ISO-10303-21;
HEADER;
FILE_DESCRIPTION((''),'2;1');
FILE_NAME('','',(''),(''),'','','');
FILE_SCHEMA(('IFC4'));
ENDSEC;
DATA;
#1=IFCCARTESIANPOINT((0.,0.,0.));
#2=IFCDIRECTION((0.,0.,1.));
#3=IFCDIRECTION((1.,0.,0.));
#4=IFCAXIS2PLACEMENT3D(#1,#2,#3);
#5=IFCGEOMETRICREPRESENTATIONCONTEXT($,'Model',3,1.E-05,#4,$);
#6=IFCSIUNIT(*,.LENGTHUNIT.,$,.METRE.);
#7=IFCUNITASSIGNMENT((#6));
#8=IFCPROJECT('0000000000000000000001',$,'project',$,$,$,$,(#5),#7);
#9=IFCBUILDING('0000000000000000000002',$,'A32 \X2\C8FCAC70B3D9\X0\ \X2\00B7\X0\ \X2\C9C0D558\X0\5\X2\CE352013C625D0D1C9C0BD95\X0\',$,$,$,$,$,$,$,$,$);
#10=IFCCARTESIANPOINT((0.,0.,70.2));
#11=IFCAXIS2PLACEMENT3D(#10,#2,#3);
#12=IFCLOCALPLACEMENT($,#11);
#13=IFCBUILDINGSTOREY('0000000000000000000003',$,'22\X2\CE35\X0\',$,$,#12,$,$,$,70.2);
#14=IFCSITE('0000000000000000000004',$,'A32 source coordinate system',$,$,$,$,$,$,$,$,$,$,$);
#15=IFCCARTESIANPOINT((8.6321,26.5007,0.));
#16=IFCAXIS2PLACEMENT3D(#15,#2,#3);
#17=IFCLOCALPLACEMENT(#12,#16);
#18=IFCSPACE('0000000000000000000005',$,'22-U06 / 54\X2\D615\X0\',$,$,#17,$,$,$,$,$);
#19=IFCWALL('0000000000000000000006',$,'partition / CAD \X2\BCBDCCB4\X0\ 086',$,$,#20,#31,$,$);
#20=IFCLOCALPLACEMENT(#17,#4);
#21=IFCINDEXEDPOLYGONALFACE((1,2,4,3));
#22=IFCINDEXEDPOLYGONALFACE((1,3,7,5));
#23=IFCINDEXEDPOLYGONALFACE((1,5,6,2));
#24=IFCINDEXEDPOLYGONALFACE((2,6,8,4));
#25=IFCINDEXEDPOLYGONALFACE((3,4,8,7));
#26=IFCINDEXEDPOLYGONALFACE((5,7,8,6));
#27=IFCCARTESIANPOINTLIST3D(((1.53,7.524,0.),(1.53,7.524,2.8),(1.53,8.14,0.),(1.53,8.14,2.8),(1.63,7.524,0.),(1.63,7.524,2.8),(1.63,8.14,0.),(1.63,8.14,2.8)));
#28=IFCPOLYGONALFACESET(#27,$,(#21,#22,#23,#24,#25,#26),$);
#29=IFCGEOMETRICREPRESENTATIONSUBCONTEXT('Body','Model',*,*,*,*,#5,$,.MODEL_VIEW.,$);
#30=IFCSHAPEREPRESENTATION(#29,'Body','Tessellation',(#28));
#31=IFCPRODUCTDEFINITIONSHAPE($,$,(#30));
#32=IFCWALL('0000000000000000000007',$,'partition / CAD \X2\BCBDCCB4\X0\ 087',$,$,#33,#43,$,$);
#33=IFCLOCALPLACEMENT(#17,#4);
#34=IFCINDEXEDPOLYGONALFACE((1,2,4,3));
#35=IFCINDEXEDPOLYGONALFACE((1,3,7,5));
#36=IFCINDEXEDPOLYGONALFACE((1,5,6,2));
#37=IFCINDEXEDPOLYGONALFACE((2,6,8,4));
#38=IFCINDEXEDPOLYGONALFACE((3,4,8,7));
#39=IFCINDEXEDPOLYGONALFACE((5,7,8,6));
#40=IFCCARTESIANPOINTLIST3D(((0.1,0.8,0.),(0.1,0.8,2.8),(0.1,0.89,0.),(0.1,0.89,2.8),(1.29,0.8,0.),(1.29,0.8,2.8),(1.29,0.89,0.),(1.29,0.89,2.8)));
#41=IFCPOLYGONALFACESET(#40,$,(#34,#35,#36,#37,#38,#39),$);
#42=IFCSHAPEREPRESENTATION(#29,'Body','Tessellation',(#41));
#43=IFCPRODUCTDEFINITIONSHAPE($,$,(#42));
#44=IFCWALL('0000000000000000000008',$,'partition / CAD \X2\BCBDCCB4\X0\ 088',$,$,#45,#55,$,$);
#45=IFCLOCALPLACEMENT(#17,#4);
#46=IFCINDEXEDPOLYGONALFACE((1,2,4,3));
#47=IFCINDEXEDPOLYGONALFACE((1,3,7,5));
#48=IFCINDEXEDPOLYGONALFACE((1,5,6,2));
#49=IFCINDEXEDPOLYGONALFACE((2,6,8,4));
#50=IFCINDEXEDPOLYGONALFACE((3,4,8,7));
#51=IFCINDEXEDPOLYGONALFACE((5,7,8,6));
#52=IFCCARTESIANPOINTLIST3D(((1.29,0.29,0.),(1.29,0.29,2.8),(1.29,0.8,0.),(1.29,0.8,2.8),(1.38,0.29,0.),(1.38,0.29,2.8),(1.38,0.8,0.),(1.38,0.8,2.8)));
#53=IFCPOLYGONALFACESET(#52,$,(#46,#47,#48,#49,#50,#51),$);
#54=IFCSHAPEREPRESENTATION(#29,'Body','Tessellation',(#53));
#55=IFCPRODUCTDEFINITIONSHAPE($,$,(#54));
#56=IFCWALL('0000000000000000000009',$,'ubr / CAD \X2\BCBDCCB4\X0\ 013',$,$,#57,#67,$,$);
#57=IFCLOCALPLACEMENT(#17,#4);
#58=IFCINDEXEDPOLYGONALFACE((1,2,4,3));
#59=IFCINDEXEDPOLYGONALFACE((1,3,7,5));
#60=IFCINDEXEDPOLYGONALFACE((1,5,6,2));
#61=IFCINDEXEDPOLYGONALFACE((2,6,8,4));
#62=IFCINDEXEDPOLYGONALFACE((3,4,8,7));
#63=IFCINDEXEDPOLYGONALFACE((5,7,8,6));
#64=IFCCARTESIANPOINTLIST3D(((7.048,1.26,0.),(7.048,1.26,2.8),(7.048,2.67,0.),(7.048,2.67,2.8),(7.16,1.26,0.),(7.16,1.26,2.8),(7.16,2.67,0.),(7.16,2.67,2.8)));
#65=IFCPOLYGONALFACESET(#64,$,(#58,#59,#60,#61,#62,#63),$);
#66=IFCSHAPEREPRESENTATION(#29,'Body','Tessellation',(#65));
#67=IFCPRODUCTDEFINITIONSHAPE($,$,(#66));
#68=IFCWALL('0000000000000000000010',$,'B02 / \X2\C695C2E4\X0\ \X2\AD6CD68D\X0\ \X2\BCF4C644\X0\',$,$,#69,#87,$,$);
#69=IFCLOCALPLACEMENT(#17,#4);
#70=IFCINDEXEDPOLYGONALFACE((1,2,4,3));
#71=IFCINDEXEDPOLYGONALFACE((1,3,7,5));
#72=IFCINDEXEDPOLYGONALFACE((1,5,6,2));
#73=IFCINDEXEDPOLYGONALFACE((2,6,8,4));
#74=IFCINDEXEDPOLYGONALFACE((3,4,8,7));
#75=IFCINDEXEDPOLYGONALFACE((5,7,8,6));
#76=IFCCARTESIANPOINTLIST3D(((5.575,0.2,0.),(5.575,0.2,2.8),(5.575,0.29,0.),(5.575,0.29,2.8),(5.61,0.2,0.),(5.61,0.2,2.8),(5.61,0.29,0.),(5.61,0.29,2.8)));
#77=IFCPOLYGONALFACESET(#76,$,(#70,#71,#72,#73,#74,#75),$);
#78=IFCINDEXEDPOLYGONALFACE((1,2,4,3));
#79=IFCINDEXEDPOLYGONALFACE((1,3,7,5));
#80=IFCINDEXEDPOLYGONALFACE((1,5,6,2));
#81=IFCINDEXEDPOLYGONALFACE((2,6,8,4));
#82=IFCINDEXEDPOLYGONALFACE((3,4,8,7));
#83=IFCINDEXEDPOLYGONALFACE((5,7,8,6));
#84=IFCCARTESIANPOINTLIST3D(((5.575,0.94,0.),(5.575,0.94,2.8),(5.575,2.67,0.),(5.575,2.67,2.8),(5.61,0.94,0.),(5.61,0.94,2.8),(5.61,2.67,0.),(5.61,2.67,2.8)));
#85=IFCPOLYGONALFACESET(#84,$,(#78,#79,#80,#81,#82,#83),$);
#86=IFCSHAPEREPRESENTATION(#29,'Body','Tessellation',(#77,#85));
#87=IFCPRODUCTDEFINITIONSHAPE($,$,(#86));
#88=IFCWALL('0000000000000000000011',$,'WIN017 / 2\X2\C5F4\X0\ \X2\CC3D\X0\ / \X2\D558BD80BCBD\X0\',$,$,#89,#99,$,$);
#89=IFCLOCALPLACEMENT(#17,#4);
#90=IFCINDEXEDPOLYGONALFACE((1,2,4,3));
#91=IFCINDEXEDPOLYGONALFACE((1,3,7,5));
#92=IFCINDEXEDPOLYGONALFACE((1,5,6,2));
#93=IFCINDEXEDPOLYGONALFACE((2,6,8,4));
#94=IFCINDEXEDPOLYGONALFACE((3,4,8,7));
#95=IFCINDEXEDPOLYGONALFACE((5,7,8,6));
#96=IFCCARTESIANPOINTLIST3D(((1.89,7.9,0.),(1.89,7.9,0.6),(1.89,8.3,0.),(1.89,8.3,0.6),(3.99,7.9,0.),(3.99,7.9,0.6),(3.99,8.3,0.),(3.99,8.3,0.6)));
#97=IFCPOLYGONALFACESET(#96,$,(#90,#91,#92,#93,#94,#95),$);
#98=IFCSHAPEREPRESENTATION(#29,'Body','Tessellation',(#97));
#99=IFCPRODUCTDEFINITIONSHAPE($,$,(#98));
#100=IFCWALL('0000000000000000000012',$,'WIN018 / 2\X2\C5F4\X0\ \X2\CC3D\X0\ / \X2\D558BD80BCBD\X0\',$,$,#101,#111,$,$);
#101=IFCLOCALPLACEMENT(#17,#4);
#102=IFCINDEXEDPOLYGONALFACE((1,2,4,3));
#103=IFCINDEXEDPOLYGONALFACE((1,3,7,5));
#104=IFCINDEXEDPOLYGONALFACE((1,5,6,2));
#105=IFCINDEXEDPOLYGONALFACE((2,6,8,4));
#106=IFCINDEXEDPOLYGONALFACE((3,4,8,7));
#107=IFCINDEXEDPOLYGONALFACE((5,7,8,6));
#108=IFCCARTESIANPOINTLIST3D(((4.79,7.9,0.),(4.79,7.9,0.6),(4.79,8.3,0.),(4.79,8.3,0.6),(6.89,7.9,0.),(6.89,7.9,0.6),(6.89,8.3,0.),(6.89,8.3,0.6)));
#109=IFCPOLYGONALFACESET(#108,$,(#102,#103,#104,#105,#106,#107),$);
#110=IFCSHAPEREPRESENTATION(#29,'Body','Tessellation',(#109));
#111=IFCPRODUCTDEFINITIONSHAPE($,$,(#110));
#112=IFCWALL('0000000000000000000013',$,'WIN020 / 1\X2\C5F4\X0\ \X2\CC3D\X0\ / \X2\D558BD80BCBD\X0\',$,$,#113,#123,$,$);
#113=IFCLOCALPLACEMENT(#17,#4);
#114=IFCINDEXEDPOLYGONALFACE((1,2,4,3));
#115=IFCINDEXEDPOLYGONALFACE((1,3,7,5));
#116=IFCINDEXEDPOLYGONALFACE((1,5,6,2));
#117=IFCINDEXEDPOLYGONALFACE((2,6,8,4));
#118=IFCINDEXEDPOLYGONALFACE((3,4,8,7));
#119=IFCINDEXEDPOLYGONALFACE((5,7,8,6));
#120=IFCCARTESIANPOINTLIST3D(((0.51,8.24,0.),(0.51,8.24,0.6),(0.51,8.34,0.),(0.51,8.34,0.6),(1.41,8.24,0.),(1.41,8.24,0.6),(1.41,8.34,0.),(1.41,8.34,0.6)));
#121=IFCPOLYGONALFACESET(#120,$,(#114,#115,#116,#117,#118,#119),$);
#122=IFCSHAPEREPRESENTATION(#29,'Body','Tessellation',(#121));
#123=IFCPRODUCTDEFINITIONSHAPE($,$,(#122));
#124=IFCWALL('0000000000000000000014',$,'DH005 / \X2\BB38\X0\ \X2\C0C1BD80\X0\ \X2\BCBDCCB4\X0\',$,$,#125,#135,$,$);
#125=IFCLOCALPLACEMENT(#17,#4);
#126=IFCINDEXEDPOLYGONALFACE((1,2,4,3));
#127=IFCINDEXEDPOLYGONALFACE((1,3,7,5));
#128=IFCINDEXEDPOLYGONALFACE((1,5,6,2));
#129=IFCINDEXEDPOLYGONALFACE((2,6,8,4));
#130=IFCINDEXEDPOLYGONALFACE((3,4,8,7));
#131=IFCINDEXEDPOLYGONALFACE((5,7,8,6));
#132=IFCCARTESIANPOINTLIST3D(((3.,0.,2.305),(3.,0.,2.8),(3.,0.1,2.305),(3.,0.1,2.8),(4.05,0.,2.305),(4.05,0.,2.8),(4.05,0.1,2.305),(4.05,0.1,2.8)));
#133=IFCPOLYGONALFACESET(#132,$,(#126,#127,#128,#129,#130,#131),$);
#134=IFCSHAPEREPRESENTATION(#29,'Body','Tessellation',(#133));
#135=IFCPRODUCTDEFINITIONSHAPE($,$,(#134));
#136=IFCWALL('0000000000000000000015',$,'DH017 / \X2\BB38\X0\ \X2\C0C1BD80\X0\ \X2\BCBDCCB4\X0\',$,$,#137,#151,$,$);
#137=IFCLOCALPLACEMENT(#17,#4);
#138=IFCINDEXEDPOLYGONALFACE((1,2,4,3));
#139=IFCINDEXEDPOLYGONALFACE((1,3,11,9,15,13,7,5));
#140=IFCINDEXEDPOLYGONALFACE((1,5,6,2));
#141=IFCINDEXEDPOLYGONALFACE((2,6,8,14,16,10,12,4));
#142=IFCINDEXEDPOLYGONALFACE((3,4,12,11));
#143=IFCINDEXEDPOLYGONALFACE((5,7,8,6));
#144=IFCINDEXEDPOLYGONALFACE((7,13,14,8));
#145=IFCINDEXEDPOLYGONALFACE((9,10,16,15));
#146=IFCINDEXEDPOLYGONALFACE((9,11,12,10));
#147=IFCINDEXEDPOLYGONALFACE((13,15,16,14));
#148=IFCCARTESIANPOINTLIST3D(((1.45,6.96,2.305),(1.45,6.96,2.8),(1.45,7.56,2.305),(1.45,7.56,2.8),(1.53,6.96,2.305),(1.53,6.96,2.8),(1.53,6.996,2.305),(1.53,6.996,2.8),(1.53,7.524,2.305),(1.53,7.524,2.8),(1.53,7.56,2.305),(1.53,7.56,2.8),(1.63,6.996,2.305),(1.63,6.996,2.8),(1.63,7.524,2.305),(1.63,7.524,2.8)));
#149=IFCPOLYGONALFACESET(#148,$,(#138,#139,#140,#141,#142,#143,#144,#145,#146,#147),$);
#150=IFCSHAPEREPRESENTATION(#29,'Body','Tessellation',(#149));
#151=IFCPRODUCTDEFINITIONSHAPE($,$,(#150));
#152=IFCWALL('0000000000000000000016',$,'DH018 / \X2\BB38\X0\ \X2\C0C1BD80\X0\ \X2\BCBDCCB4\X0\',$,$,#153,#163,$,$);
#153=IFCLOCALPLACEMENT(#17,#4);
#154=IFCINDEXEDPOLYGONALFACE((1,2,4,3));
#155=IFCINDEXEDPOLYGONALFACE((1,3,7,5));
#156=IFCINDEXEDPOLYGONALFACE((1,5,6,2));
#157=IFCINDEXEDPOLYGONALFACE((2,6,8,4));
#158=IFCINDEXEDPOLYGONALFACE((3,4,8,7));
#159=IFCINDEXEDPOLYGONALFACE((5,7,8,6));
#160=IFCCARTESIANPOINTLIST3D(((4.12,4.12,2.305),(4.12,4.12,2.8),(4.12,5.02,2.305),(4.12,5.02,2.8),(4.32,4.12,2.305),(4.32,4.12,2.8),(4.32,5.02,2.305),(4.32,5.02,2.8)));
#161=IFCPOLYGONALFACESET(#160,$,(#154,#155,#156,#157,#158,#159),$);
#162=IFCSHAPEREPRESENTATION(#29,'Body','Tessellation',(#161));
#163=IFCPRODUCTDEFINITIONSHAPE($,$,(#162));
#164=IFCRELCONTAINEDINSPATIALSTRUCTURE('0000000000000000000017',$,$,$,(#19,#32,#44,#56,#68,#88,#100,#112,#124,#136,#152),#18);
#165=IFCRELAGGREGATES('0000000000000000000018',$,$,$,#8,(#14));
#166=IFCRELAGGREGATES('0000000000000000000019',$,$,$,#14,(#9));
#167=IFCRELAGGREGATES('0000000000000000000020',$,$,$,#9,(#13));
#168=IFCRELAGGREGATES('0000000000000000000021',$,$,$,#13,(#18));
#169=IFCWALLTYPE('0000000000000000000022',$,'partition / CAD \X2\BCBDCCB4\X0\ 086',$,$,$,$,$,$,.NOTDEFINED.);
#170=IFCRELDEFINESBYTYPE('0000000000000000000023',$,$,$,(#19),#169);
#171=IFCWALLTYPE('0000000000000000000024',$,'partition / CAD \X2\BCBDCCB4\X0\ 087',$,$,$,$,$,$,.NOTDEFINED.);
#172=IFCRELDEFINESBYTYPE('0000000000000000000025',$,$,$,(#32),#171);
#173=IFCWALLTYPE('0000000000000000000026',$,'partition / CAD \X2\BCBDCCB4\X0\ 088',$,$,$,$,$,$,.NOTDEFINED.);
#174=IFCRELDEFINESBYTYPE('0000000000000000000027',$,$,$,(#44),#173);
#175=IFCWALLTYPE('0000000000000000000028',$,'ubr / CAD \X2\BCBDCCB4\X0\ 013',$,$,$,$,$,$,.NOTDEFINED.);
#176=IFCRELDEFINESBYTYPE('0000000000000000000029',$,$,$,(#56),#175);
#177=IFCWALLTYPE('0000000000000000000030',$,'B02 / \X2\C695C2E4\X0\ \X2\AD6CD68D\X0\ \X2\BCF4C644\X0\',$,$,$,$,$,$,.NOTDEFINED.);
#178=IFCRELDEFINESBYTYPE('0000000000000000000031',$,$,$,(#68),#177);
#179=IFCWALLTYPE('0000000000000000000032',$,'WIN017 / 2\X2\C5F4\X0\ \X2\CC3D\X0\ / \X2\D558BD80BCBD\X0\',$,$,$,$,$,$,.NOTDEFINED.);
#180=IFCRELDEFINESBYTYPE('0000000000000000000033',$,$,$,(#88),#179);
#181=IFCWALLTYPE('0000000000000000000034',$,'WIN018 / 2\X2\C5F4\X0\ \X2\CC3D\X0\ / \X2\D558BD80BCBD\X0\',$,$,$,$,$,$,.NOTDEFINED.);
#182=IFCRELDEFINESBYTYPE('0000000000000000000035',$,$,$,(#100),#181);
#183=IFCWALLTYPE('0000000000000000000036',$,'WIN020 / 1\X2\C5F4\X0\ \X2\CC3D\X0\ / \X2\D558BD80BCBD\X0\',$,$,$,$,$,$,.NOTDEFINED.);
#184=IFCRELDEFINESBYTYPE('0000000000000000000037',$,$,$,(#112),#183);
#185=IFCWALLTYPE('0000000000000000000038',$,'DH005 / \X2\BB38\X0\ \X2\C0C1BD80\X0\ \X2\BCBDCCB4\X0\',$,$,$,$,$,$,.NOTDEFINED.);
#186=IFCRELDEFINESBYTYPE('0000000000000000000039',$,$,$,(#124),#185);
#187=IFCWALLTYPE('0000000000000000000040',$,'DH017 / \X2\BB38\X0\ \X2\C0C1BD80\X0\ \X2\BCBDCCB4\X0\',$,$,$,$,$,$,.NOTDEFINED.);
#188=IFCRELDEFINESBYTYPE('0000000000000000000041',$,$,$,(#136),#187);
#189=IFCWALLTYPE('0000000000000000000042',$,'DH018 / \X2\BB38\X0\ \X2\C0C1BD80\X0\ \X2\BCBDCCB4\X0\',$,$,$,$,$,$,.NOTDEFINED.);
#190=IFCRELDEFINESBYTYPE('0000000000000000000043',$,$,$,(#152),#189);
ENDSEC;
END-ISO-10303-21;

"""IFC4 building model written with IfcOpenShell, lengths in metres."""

from ifc_helpers import new_model, si_unit, frame, origin, origin_with_axes, place, context, subcontext, project, spatial, polyline, outline, extrude, source, transform, mapped, type_object, type_shapes, element, save


model = new_model("IFC4")

# Units and contexts
model_context = context("Model", 3, precision=1e-05, world=origin_with_axes())
body_context = subcontext(model_context, "Body", "Model", "MODEL_VIEW")
ifc_project = project(units=[si_unit("LENGTHUNIT", "METRE")], contexts=[model_context])

# Site, building, storey, space
site = spatial("IfcSite", under=ifc_project, Name="A32 source coordinate system")
building = spatial("IfcBuilding", under=site, Name="A32 주거동 · 지하5층–옥탑지붕")
storey_placement = place(None, frame((0.0, 0.0, 70.2), z_axis=(0.0, 0.0, 1.0), x_axis=(1.0, 0.0, 0.0)))
storey = spatial("IfcBuildingStorey", under=building, at=storey_placement, Name="22층", Elevation=70.2)
space_placement = place(storey_placement, frame((8.6321, 26.5007, 0.0), z_axis=(0.0, 0.0, 1.0), x_axis=(1.0, 0.0, 0.0)))
space = spatial("IfcSpace", under=storey, at=space_placement, Name="22-U06 / 54형")

# Walls
wall_type_1 = type_object("IfcWallType", Name="partition / CAD 벽체 086", PredefinedType="NOTDEFINED")
shared_shape_1 = source(origin(), body_context, "Body", "SweptSolid", [
    extrude(outline(polyline([(1.53, 7.524), (1.53, 8.14), (1.63, 8.14), (1.63, 7.524), (1.53, 7.524)])), origin(), (0.0, 0.0, 1.0), 2.8),
])
type_shapes(wall_type_1, [shared_shape_1])
wall_1_placement = place(space_placement, origin_with_axes())
element("IfcWall", 1, at=wall_1_placement, inside=space, type_object=wall_type_1, Name="partition / CAD 벽체 086", context=body_context, shape_type="MappedRepresentation", body=[
    mapped(shared_shape_1, transform((0.0, 0.0, 0.0), scale=1.0)),
])
wall_type_2 = type_object("IfcWallType", Name="partition / CAD 벽체 087", PredefinedType="NOTDEFINED")
shared_shape_2 = source(origin(), body_context, "Body", "SweptSolid", [
    extrude(outline(polyline([(1.29, 0.8), (0.1, 0.8), (0.1, 0.89), (1.29, 0.89), (1.29, 0.8)])), origin(), (0.0, 0.0, 1.0), 2.8),
])
type_shapes(wall_type_2, [shared_shape_2])
wall_2_placement = place(space_placement, origin_with_axes())
element("IfcWall", 2, at=wall_2_placement, inside=space, type_object=wall_type_2, Name="partition / CAD 벽체 087", context=body_context, shape_type="MappedRepresentation", body=[
    mapped(shared_shape_2, transform((0.0, 0.0, 0.0), scale=1.0)),
])
wall_type_3 = type_object("IfcWallType", Name="partition / CAD 벽체 088", PredefinedType="NOTDEFINED")
shared_shape_3 = source(origin(), body_context, "Body", "SweptSolid", [
    extrude(outline(polyline([(1.29, 0.29), (1.29, 0.8), (1.38, 0.8), (1.38, 0.29), (1.29, 0.29)])), origin(), (0.0, 0.0, 1.0), 2.8),
])
type_shapes(wall_type_3, [shared_shape_3])
wall_3_placement = place(space_placement, origin_with_axes())
element("IfcWall", 3, at=wall_3_placement, inside=space, type_object=wall_type_3, Name="partition / CAD 벽체 088", context=body_context, shape_type="MappedRepresentation", body=[
    mapped(shared_shape_3, transform((0.0, 0.0, 0.0), scale=1.0)),
])
wall_type_4 = type_object("IfcWallType", Name="ubr / CAD 벽체 013", PredefinedType="NOTDEFINED")
shared_shape_4 = source(origin(), body_context, "Body", "SweptSolid", [
    extrude(outline(polyline([(7.16, 1.26), (7.048, 1.26), (7.048, 2.67), (7.16, 2.67), (7.16, 1.26)])), origin(), (0.0, 0.0, 1.0), 2.8),
])
type_shapes(wall_type_4, [shared_shape_4])
wall_4_placement = place(space_placement, origin_with_axes())
element("IfcWall", 4, at=wall_4_placement, inside=space, type_object=wall_type_4, Name="ubr / CAD 벽체 013", context=body_context, shape_type="MappedRepresentation", body=[
    mapped(shared_shape_4, transform((0.0, 0.0, 0.0), scale=1.0)),
])
wall_type_5 = type_object("IfcWallType", Name="B02 / 욕실 구획 보완", PredefinedType="NOTDEFINED")
shared_shape_5 = source(origin(), body_context, "Body", "SweptSolid", [
    extrude(outline(polyline([(5.575, 0.2), (5.575, 0.29), (5.61, 0.29), (5.61, 0.2), (5.575, 0.2)])), origin(), (0.0, 0.0, 1.0), 2.8),
    extrude(outline(polyline([(5.575, 0.94), (5.575, 2.67), (5.61, 2.67), (5.61, 0.94), (5.575, 0.94)])), origin(), (0.0, 0.0, 1.0), 2.8),
])
type_shapes(wall_type_5, [shared_shape_5])
wall_5_placement = place(space_placement, origin_with_axes())
element("IfcWall", 5, at=wall_5_placement, inside=space, type_object=wall_type_5, Name="B02 / 욕실 구획 보완", context=body_context, shape_type="MappedRepresentation", body=[
    mapped(shared_shape_5, transform((0.0, 0.0, 0.0), scale=1.0)),
])
wall_type_6 = type_object("IfcWallType", Name="WIN017 / 2열 창 / 하부벽", PredefinedType="NOTDEFINED")
shared_shape_6 = source(origin(), body_context, "Body", "SweptSolid", [
    extrude(outline(polyline([(3.99, 8.3), (3.99, 7.9), (1.89, 7.9), (1.89, 8.3), (3.99, 8.3)])), origin(), (0.0, 0.0, 1.0), 0.6),
])
type_shapes(wall_type_6, [shared_shape_6])
wall_6_placement = place(space_placement, origin_with_axes())
element("IfcWall", 6, at=wall_6_placement, inside=space, type_object=wall_type_6, Name="WIN017 / 2열 창 / 하부벽", context=body_context, shape_type="MappedRepresentation", body=[
    mapped(shared_shape_6, transform((0.0, 0.0, 0.0), scale=1.0)),
])
wall_type_7 = type_object("IfcWallType", Name="WIN018 / 2열 창 / 하부벽", PredefinedType="NOTDEFINED")
shared_shape_7 = source(origin(), body_context, "Body", "SweptSolid", [
    extrude(outline(polyline([(6.89, 8.3), (6.89, 7.9), (4.79, 7.9), (4.79, 8.3), (6.89, 8.3)])), origin(), (0.0, 0.0, 1.0), 0.6),
])
type_shapes(wall_type_7, [shared_shape_7])
wall_7_placement = place(space_placement, origin_with_axes())
element("IfcWall", 7, at=wall_7_placement, inside=space, type_object=wall_type_7, Name="WIN018 / 2열 창 / 하부벽", context=body_context, shape_type="MappedRepresentation", body=[
    mapped(shared_shape_7, transform((0.0, 0.0, 0.0), scale=1.0)),
])
wall_type_8 = type_object("IfcWallType", Name="WIN020 / 1열 창 / 하부벽", PredefinedType="NOTDEFINED")
shared_shape_8 = source(origin(), body_context, "Body", "SweptSolid", [
    extrude(outline(polyline([(1.41, 8.34), (1.41, 8.24), (0.51, 8.24), (0.51, 8.34), (1.41, 8.34)])), origin(), (0.0, 0.0, 1.0), 0.6),
])
type_shapes(wall_type_8, [shared_shape_8])
wall_8_placement = place(space_placement, origin_with_axes())
element("IfcWall", 8, at=wall_8_placement, inside=space, type_object=wall_type_8, Name="WIN020 / 1열 창 / 하부벽", context=body_context, shape_type="MappedRepresentation", body=[
    mapped(shared_shape_8, transform((0.0, 0.0, 0.0), scale=1.0)),
])
wall_type_9 = type_object("IfcWallType", Name="DH005 / 문 상부 벽체", PredefinedType="NOTDEFINED")
shared_shape_9 = source(origin(), body_context, "Body", "SweptSolid", [
    extrude(outline(polyline([(4.05, 0.0), (3.0, 0.0), (3.0, 0.1), (4.05, 0.1), (4.05, 0.0)])), frame((0.0, 0.0, 2.305)), (0.0, 0.0, 1.0), 0.495),
])
type_shapes(wall_type_9, [shared_shape_9])
wall_9_placement = place(space_placement, origin_with_axes())
element("IfcWall", 9, at=wall_9_placement, inside=space, type_object=wall_type_9, Name="DH005 / 문 상부 벽체", context=body_context, shape_type="MappedRepresentation", body=[
    mapped(shared_shape_9, transform((0.0, 0.0, 0.0), scale=1.0)),
])
wall_type_10 = type_object("IfcWallType", Name="DH017 / 문 상부 벽체", PredefinedType="NOTDEFINED")
shared_shape_10 = source(origin(), body_context, "Body", "SweptSolid", [
    extrude(outline(polyline([(1.63, 7.524), (1.63, 6.996), (1.53, 6.996), (1.53, 6.96), (1.45, 6.96), (1.45, 7.56), (1.53, 7.56), (1.53, 7.524), (1.63, 7.524)])), frame((0.0, 0.0, 2.305)), (0.0, 0.0, 1.0), 0.495),
])
type_shapes(wall_type_10, [shared_shape_10])
wall_10_placement = place(space_placement, origin_with_axes())
element("IfcWall", 10, at=wall_10_placement, inside=space, type_object=wall_type_10, Name="DH017 / 문 상부 벽체", context=body_context, shape_type="MappedRepresentation", body=[
    mapped(shared_shape_10, transform((0.0, 0.0, 0.0), scale=1.0)),
])
wall_type_11 = type_object("IfcWallType", Name="DH018 / 문 상부 벽체", PredefinedType="NOTDEFINED")
shared_shape_11 = source(origin(), body_context, "Body", "SweptSolid", [
    extrude(outline(polyline([(4.32, 4.12), (4.12, 4.12), (4.12, 5.02), (4.32, 5.02), (4.32, 4.12)])), frame((0.0, 0.0, 2.305)), (0.0, 0.0, 1.0), 0.495),
])
type_shapes(wall_type_11, [shared_shape_11])
wall_11_placement = place(space_placement, origin_with_axes())
element("IfcWall", 11, at=wall_11_placement, inside=space, type_object=wall_type_11, Name="DH018 / 문 상부 벽체", context=body_context, shape_type="MappedRepresentation", body=[
    mapped(shared_shape_11, transform((0.0, 0.0, 0.0), scale=1.0)),
])

save(model, "model.ifc")
